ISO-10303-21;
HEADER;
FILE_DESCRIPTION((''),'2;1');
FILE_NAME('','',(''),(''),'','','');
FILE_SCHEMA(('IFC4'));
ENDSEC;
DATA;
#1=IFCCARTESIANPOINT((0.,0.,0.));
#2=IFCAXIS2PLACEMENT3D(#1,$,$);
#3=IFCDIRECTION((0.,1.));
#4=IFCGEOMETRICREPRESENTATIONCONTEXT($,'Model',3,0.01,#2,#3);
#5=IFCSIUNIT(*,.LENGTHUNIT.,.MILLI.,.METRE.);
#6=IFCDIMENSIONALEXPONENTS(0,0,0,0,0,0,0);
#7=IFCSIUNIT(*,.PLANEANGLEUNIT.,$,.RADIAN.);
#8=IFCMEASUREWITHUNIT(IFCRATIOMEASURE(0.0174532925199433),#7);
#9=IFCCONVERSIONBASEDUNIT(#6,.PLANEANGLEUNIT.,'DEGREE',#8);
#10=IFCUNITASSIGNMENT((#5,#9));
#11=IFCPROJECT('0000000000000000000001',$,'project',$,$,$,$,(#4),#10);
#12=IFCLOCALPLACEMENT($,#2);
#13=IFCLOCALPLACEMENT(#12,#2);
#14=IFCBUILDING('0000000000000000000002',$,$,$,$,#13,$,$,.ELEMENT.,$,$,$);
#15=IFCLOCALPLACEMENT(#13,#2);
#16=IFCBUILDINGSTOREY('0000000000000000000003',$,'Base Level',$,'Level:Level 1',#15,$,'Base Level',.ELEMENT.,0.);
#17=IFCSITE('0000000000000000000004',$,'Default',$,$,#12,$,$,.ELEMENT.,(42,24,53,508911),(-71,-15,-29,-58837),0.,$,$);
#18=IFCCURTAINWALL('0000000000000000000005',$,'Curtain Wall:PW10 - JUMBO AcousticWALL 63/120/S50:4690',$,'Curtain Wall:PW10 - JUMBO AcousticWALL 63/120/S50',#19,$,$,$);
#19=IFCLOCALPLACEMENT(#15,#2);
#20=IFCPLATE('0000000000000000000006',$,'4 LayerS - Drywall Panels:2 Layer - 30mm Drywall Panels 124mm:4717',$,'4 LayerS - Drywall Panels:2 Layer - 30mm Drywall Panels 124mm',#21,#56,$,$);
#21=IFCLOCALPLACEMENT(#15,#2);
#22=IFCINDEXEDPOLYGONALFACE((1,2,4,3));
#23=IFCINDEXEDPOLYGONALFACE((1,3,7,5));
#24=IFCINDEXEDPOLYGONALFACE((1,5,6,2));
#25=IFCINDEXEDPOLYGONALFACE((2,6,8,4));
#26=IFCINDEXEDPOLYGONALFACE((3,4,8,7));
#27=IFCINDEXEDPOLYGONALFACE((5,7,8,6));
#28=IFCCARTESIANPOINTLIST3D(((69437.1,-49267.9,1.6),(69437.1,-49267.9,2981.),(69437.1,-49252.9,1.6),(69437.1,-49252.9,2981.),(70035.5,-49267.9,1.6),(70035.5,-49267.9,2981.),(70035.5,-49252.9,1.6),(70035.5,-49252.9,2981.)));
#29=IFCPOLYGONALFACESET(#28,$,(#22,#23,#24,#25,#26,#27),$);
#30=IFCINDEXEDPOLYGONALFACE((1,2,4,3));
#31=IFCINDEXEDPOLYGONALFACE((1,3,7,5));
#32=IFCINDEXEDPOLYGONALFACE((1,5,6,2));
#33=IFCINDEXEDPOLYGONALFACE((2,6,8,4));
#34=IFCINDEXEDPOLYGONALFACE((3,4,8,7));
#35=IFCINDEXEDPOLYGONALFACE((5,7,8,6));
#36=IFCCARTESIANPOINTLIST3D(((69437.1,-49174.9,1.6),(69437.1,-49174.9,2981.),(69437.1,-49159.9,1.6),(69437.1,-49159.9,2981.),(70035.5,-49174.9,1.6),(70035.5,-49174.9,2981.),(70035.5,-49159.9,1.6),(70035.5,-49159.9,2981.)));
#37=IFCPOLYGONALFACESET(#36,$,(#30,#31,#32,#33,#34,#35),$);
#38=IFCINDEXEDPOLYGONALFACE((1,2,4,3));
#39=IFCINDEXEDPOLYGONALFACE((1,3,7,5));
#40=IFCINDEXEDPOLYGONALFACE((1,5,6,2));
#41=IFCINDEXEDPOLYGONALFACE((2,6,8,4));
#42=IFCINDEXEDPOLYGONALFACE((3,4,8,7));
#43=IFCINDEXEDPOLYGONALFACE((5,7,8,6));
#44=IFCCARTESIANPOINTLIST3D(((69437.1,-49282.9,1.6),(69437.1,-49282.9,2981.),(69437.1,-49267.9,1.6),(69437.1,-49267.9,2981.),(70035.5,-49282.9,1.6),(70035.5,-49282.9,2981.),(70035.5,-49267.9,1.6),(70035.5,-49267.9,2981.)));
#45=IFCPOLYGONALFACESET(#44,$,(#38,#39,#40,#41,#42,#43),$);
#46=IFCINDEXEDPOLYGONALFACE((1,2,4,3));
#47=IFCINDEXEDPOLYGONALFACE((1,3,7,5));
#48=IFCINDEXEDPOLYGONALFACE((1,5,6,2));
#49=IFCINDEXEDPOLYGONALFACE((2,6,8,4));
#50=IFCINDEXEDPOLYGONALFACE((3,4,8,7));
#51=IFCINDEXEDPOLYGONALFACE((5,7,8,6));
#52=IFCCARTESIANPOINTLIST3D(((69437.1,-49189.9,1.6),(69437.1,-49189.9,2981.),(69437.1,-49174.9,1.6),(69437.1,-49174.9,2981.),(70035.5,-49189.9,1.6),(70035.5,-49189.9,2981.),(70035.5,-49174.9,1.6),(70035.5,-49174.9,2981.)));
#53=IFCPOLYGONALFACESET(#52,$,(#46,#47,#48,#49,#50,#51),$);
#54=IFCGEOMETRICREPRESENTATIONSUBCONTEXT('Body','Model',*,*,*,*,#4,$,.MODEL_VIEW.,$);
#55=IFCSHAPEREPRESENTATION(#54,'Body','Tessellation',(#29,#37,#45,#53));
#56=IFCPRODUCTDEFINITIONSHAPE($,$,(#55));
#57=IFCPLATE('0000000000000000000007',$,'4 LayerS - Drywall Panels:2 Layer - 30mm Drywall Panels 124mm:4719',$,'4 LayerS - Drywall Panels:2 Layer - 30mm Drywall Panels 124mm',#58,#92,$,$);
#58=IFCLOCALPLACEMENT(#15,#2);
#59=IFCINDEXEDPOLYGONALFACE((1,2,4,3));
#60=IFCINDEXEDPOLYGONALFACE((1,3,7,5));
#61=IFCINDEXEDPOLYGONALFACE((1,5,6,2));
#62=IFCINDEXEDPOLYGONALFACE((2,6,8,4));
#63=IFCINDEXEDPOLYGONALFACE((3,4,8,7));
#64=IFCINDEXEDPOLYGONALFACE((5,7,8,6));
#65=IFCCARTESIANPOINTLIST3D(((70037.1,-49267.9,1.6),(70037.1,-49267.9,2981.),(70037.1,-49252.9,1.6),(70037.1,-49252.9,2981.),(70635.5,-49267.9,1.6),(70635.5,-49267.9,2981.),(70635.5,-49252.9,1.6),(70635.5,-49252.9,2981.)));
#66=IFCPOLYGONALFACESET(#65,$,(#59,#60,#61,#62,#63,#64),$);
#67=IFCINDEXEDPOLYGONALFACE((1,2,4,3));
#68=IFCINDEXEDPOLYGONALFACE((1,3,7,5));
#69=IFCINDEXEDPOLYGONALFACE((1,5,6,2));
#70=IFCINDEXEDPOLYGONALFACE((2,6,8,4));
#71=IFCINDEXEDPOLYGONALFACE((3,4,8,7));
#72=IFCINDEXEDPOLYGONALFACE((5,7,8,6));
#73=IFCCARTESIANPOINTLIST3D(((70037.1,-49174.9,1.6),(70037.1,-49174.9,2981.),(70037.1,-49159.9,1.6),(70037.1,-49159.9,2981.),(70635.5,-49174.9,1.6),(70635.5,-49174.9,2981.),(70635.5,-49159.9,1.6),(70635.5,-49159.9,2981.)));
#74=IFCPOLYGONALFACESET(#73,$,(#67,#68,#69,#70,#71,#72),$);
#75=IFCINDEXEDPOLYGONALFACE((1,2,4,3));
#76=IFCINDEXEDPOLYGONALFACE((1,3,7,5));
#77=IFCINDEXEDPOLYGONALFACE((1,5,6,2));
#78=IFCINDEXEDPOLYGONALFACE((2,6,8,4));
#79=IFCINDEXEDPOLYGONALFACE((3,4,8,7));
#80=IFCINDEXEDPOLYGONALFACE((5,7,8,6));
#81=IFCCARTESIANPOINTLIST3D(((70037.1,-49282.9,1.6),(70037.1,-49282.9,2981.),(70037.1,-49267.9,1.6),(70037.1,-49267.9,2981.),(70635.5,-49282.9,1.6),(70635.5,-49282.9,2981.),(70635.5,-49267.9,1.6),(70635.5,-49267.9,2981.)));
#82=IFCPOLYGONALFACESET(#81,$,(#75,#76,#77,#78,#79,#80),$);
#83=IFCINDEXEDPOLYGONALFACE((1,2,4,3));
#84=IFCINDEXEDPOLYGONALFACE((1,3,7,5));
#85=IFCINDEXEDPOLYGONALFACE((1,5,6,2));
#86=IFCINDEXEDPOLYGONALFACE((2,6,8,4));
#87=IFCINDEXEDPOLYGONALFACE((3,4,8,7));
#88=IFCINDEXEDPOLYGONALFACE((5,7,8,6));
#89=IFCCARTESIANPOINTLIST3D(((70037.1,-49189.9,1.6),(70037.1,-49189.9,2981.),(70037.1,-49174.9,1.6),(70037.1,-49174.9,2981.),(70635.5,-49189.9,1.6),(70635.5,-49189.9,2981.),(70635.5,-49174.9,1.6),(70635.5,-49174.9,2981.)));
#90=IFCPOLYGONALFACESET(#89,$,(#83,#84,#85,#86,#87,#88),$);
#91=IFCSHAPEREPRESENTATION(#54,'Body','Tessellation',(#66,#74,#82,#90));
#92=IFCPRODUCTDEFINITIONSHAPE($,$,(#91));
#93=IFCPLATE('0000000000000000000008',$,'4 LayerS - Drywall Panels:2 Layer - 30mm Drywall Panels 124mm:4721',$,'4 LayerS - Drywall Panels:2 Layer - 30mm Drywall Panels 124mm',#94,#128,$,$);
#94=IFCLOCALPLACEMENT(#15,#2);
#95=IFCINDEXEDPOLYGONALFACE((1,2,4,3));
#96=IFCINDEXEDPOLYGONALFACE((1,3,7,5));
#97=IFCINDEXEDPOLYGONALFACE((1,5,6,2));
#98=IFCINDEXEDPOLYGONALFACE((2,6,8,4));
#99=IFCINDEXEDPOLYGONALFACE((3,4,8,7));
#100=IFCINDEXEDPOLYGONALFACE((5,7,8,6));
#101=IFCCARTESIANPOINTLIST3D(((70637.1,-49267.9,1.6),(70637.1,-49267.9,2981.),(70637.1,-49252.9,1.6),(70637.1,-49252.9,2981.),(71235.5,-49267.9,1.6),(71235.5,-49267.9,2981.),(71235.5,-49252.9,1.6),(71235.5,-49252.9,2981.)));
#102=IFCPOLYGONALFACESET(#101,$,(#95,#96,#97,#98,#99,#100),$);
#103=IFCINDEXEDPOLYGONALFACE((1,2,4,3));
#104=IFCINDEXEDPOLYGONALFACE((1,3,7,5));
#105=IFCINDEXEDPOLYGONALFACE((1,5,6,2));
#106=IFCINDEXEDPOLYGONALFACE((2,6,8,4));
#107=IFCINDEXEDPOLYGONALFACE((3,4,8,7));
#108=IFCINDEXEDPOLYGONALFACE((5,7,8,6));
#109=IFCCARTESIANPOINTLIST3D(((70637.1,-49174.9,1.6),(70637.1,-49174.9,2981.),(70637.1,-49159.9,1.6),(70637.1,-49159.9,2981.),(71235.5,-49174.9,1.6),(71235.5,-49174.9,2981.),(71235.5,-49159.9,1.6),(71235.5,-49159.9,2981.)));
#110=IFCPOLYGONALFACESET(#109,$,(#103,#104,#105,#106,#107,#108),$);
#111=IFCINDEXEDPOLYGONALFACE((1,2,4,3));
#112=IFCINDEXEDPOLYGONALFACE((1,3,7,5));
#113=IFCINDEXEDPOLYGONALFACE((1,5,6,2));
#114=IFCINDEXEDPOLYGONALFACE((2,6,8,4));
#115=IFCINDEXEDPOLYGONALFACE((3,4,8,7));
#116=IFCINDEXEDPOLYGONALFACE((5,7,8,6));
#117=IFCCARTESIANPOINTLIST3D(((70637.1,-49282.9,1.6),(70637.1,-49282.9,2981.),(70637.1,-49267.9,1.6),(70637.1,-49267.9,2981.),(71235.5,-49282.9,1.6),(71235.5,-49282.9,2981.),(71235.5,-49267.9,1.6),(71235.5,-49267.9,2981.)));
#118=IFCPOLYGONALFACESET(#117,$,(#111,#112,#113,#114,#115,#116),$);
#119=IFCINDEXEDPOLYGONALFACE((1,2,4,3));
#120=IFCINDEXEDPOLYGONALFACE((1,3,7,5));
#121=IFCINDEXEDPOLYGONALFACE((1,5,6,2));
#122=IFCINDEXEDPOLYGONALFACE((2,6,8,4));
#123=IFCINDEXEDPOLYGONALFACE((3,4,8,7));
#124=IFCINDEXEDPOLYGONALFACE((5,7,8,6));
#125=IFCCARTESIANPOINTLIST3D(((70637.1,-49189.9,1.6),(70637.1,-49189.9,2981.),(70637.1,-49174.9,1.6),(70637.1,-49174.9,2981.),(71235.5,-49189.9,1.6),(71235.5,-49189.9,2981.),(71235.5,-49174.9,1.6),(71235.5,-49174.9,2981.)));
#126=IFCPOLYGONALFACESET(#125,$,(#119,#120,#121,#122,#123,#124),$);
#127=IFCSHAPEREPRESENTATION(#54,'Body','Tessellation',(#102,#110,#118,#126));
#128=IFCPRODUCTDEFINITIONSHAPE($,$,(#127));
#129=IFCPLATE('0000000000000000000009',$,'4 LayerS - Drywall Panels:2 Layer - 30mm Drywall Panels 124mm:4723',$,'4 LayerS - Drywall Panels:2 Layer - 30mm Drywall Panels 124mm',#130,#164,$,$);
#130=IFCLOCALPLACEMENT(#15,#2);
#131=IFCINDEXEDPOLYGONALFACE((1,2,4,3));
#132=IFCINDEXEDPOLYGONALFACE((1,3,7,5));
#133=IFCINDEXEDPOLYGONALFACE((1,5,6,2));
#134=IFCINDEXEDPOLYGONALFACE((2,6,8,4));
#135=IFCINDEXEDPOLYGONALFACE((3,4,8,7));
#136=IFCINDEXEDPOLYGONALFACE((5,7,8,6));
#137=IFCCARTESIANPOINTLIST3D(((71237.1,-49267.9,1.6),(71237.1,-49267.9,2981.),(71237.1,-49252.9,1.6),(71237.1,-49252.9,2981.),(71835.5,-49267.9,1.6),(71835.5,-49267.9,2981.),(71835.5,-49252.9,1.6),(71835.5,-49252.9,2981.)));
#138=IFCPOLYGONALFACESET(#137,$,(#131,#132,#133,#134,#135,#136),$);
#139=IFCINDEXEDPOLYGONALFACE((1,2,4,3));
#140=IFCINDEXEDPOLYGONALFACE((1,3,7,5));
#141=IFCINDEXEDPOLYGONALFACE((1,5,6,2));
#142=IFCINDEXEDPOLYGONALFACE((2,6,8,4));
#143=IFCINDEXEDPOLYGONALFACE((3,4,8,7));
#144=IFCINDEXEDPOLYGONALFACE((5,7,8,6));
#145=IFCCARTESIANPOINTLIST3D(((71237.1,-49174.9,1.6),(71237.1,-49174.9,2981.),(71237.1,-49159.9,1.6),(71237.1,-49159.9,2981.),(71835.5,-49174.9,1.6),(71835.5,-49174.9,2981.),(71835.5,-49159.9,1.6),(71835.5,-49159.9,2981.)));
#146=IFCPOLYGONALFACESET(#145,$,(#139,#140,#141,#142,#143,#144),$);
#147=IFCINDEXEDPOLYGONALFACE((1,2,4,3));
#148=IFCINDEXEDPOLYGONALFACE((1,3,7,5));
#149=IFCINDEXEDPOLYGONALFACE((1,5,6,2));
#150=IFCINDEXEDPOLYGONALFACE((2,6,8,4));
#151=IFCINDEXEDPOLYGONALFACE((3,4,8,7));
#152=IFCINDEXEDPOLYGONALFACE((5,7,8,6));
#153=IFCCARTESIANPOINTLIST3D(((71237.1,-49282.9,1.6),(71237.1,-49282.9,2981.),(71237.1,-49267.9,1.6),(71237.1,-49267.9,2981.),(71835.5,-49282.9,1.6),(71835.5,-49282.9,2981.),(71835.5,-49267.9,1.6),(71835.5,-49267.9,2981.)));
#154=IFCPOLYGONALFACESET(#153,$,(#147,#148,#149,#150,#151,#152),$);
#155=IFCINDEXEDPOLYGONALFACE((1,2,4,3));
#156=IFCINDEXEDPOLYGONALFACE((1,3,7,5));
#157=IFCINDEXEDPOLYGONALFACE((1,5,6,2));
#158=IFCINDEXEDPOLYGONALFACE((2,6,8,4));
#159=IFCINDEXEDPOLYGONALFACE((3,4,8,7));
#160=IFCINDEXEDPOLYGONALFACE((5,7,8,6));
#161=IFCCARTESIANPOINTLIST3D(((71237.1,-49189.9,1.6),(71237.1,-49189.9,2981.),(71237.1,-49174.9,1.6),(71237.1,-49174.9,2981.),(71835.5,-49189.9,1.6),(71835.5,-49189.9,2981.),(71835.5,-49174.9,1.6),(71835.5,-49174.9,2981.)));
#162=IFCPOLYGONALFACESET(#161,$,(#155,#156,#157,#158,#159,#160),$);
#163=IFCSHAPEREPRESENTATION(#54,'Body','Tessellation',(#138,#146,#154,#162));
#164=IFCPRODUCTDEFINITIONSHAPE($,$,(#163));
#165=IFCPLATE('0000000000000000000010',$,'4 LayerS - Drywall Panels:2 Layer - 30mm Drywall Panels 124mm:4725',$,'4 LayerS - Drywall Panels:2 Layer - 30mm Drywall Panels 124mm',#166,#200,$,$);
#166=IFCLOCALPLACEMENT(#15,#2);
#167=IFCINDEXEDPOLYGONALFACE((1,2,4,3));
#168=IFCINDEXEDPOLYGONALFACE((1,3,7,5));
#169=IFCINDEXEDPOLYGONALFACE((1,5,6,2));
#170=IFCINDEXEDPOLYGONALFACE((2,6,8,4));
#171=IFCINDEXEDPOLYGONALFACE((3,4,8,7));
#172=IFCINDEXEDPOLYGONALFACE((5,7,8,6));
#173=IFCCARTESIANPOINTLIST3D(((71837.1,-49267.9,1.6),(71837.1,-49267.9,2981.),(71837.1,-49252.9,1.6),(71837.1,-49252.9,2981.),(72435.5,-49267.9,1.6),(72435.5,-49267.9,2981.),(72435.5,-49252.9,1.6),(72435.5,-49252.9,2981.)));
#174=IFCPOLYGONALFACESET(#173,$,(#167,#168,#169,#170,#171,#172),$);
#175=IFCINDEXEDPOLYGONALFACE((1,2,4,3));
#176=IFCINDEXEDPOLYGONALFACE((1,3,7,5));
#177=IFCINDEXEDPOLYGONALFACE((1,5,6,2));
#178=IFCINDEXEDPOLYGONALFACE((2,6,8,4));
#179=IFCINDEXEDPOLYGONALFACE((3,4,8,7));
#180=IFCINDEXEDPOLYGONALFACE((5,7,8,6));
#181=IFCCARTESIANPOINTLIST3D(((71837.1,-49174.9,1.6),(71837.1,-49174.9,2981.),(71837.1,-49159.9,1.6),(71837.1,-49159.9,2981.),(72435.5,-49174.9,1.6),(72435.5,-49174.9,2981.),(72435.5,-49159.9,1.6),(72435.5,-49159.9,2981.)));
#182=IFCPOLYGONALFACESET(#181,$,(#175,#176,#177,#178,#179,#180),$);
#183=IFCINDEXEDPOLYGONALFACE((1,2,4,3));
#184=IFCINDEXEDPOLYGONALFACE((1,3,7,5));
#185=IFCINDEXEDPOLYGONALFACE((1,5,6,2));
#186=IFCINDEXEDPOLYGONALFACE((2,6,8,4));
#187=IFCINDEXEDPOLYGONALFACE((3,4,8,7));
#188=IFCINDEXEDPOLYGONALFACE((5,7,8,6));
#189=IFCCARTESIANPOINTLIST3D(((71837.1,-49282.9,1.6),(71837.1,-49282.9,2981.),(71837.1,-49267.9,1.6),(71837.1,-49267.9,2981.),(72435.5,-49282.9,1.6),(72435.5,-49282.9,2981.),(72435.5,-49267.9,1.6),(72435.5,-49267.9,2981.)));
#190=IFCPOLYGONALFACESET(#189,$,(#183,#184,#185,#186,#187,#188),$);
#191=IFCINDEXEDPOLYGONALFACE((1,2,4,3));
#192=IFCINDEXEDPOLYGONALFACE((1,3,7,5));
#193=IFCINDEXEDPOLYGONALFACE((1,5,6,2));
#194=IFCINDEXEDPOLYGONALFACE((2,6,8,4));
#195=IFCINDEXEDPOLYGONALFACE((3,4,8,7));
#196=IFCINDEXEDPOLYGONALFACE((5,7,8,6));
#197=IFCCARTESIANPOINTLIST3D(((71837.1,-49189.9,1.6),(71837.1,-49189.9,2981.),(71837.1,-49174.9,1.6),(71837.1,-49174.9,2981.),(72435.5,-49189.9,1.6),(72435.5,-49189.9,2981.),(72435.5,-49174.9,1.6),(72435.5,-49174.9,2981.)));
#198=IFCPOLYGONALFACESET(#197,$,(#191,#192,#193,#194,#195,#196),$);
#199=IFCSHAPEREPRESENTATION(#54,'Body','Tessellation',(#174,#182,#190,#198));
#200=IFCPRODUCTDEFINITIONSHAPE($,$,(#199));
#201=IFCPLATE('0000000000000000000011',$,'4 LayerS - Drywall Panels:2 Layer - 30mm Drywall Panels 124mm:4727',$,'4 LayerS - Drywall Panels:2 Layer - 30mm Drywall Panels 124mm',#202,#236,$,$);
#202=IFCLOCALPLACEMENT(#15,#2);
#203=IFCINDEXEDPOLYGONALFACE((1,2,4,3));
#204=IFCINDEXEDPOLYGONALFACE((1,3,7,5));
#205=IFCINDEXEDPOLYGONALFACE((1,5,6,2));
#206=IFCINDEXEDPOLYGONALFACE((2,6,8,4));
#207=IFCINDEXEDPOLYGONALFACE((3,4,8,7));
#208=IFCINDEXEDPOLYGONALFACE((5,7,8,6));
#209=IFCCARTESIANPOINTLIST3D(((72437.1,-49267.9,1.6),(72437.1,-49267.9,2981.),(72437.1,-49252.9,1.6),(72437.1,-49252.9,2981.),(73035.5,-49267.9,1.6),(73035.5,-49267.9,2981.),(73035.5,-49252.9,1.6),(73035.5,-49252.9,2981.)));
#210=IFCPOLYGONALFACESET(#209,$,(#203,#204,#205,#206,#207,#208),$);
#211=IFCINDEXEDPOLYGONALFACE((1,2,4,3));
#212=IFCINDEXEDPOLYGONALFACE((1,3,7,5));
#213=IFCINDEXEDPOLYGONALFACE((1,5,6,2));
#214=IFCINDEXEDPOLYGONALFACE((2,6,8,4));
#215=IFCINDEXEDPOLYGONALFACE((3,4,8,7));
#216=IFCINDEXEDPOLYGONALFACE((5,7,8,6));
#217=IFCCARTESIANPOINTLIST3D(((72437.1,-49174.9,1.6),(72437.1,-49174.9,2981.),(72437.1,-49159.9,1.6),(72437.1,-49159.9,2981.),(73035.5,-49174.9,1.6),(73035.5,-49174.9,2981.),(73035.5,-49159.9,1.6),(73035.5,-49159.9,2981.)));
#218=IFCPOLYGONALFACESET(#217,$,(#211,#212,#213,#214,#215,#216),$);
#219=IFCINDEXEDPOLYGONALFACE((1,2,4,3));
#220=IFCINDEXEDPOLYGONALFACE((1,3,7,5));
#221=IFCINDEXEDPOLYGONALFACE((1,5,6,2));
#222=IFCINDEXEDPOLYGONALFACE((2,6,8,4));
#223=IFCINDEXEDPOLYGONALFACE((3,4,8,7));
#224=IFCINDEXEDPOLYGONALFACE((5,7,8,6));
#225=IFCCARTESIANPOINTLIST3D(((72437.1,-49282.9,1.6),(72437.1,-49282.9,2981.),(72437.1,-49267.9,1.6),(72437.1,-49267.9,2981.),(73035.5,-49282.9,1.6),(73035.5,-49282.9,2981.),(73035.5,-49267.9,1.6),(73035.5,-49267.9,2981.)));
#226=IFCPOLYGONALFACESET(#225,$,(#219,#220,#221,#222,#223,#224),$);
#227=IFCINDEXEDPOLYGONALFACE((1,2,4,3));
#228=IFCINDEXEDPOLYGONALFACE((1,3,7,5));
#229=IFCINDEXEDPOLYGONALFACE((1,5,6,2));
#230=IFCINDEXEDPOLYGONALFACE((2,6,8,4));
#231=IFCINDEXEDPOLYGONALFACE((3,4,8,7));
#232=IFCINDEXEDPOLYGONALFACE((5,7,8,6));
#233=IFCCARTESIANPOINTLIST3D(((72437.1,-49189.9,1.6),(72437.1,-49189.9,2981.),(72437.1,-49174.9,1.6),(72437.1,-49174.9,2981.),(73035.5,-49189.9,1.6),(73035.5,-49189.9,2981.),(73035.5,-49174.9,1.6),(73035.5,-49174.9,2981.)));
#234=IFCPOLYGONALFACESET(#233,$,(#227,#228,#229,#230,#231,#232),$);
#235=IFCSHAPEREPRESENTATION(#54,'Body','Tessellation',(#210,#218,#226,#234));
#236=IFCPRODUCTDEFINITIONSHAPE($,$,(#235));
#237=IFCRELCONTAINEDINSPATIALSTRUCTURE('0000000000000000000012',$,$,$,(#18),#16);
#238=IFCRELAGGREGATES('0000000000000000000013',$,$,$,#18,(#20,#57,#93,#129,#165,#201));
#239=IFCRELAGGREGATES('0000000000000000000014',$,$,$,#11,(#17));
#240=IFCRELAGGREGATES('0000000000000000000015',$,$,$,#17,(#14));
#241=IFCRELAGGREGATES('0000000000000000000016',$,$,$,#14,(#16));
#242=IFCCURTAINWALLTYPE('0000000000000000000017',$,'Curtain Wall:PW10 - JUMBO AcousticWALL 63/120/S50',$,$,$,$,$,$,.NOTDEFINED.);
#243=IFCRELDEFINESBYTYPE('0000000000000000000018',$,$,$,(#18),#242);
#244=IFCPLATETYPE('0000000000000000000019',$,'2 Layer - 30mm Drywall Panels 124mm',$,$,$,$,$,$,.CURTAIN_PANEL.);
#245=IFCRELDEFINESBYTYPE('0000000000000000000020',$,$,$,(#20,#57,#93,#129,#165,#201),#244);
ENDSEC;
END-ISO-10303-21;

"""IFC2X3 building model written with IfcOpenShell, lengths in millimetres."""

from ifc_helpers import new_model, entity, si_unit, converted_unit, direction, frame, frame_2d, origin, origin_2d_with_axis, place, context, subcontext, project, spatial, rectangle, extrude, source, transform, mapped, type_object, type_shapes, element, aggregate, save


model = new_model("IFC2X3")

# Units and contexts
model_context = context("Model", 3, precision=0.01, world=origin(), true_north=direction((0.0, 1.0)))
body_context = subcontext(model_context, "Body", "Model", "MODEL_VIEW")
ifc_project = project(units=[si_unit("LENGTHUNIT", "METRE", prefix="MILLI"), converted_unit("PLANEANGLEUNIT", "DEGREE", entity("IfcRatioMeasure", 0.0174532925199433), si_unit("PLANEANGLEUNIT", "RADIAN"), dimensions=[0, 0, 0, 0, 0, 0, 0])], contexts=[model_context])

# Site, building, storey
site_placement = place(None, origin())
site = spatial("IfcSite", under=ifc_project, at=site_placement, Name="Default", CompositionType="ELEMENT", RefLatitude=(42, 24, 53, 508911), RefLongitude=(-71, -15, -29, -58837), RefElevation=0.0)
building_placement = place(site_placement, origin())
building = spatial("IfcBuilding", under=site, at=building_placement, CompositionType="ELEMENT")
storey_placement = place(building_placement, origin())
storey = spatial("IfcBuildingStorey", under=building, at=storey_placement, Name="Base Level", ObjectType="Level:Level 1", LongName="Base Level", CompositionType="ELEMENT", Elevation=0.0)

# Curtain wall, plates
curtain_wall_type = type_object("IfcCurtainWallType", Name="Curtain Wall:PW10 - JUMBO AcousticWALL 63/120/S50", PredefinedType="NOTDEFINED")
curtain_wall_placement = place(building_placement, origin())
curtain_wall = element("IfcCurtainWall", 1, at=curtain_wall_placement, inside=storey, type_object=curtain_wall_type, Name="Curtain Wall:PW10 - JUMBO AcousticWALL 63/120/S50:4690", ObjectType="Curtain Wall:PW10 - JUMBO AcousticWALL 63/120/S50")
plate_type = type_object("IfcPlateType", Name="2 Layer - 30mm Drywall Panels 124mm", PredefinedType="CURTAIN_PANEL")
shared_shape_1 = source(origin(), body_context, "Body", "SweptSolid", [
    extrude(rectangle(XDim=15.0, YDim=598.4, at=origin_2d_with_axis()), frame((0.0, -39.0, 0.0), z_axis=(0.0, 0.0, 1.0), x_axis=(0.0, 1.0, 0.0)), (0.0, 0.0, 1.0), 2979.4),
    extrude(rectangle(XDim=15.0, YDim=598.4, at=origin_2d_with_axis()), frame((0.0, 54.0, 0.0), z_axis=(0.0, 0.0, 1.0), x_axis=(0.0, 1.0, 0.0)), (0.0, 0.0, 1.0), 2979.4),
    extrude(rectangle(XDim=598.4, YDim=15.0, at=frame_2d((0.0, 0.0), x_axis=(1.0, 0.0))), frame((0.0, -54.0, 0.0), z_axis=(0.0, 0.0, 1.0), x_axis=(-1.0, 0.0, 0.0)), (0.0, 0.0, 1.0), 2979.4),
    extrude(rectangle(XDim=15.0, YDim=598.4, at=frame_2d((0.0, 0.0), x_axis=(1.0, 0.0))), frame((0.0, 39.0, 0.0), z_axis=(0.0, 0.0, 1.0), x_axis=(0.0, 1.0, 0.0)), (0.0, 0.0, 1.0), 2979.4),
])
type_shapes(plate_type, [shared_shape_1])
plate_1_placement = place(curtain_wall_placement, frame((69736.3, -49221.4, 1.6)))
plate_1 = element("IfcPlate", 2, at=plate_1_placement, type_object=plate_type, Name="4 LayerS - Drywall Panels:2 Layer - 30mm Drywall Panels 124mm:4717", ObjectType="4 LayerS - Drywall Panels:2 Layer - 30mm Drywall Panels 124mm", context=body_context, shape_type="MappedRepresentation", body=[
    mapped(shared_shape_1, transform((0.0, 0.0, 0.0), scale=1.0)),
])
plate_2_placement = place(curtain_wall_placement, frame((70336.3, -49221.4, 1.6)))
plate_2 = element("IfcPlate", 3, at=plate_2_placement, type_object=plate_type, Name="4 LayerS - Drywall Panels:2 Layer - 30mm Drywall Panels 124mm:4719", ObjectType="4 LayerS - Drywall Panels:2 Layer - 30mm Drywall Panels 124mm", context=body_context, shape_type="MappedRepresentation", body=[
    mapped(shared_shape_1, transform((0.0, 0.0, 0.0), scale=1.0)),
])
plate_3_placement = place(curtain_wall_placement, frame((70936.3, -49221.4, 1.6)))
plate_3 = element("IfcPlate", 4, at=plate_3_placement, type_object=plate_type, Name="4 LayerS - Drywall Panels:2 Layer - 30mm Drywall Panels 124mm:4721", ObjectType="4 LayerS - Drywall Panels:2 Layer - 30mm Drywall Panels 124mm", context=body_context, shape_type="MappedRepresentation", body=[
    mapped(shared_shape_1, transform((0.0, 0.0, 0.0), scale=1.0)),
])
plate_4_placement = place(curtain_wall_placement, frame((71536.3, -49221.4, 1.6)))
plate_4 = element("IfcPlate", 5, at=plate_4_placement, type_object=plate_type, Name="4 LayerS - Drywall Panels:2 Layer - 30mm Drywall Panels 124mm:4723", ObjectType="4 LayerS - Drywall Panels:2 Layer - 30mm Drywall Panels 124mm", context=body_context, shape_type="MappedRepresentation", body=[
    mapped(shared_shape_1, transform((0.0, 0.0, 0.0), scale=1.0)),
])
plate_5_placement = place(curtain_wall_placement, frame((72136.3, -49221.4, 1.6)))
plate_5 = element("IfcPlate", 6, at=plate_5_placement, type_object=plate_type, Name="4 LayerS - Drywall Panels:2 Layer - 30mm Drywall Panels 124mm:4725", ObjectType="4 LayerS - Drywall Panels:2 Layer - 30mm Drywall Panels 124mm", context=body_context, shape_type="MappedRepresentation", body=[
    mapped(shared_shape_1, transform((0.0, 0.0, 0.0), scale=1.0)),
])
plate_6_placement = place(curtain_wall_placement, frame((72736.3, -49221.4, 1.6)))
plate_6 = element("IfcPlate", 7, at=plate_6_placement, type_object=plate_type, Name="4 LayerS - Drywall Panels:2 Layer - 30mm Drywall Panels 124mm:4727", ObjectType="4 LayerS - Drywall Panels:2 Layer - 30mm Drywall Panels 124mm", context=body_context, shape_type="MappedRepresentation", body=[
    mapped(shared_shape_1, transform((0.0, 0.0, 0.0), scale=1.0)),
])
aggregate(curtain_wall, [plate_1, plate_2, plate_3, plate_4, plate_5, plate_6])

save(model, "model.ifc")
